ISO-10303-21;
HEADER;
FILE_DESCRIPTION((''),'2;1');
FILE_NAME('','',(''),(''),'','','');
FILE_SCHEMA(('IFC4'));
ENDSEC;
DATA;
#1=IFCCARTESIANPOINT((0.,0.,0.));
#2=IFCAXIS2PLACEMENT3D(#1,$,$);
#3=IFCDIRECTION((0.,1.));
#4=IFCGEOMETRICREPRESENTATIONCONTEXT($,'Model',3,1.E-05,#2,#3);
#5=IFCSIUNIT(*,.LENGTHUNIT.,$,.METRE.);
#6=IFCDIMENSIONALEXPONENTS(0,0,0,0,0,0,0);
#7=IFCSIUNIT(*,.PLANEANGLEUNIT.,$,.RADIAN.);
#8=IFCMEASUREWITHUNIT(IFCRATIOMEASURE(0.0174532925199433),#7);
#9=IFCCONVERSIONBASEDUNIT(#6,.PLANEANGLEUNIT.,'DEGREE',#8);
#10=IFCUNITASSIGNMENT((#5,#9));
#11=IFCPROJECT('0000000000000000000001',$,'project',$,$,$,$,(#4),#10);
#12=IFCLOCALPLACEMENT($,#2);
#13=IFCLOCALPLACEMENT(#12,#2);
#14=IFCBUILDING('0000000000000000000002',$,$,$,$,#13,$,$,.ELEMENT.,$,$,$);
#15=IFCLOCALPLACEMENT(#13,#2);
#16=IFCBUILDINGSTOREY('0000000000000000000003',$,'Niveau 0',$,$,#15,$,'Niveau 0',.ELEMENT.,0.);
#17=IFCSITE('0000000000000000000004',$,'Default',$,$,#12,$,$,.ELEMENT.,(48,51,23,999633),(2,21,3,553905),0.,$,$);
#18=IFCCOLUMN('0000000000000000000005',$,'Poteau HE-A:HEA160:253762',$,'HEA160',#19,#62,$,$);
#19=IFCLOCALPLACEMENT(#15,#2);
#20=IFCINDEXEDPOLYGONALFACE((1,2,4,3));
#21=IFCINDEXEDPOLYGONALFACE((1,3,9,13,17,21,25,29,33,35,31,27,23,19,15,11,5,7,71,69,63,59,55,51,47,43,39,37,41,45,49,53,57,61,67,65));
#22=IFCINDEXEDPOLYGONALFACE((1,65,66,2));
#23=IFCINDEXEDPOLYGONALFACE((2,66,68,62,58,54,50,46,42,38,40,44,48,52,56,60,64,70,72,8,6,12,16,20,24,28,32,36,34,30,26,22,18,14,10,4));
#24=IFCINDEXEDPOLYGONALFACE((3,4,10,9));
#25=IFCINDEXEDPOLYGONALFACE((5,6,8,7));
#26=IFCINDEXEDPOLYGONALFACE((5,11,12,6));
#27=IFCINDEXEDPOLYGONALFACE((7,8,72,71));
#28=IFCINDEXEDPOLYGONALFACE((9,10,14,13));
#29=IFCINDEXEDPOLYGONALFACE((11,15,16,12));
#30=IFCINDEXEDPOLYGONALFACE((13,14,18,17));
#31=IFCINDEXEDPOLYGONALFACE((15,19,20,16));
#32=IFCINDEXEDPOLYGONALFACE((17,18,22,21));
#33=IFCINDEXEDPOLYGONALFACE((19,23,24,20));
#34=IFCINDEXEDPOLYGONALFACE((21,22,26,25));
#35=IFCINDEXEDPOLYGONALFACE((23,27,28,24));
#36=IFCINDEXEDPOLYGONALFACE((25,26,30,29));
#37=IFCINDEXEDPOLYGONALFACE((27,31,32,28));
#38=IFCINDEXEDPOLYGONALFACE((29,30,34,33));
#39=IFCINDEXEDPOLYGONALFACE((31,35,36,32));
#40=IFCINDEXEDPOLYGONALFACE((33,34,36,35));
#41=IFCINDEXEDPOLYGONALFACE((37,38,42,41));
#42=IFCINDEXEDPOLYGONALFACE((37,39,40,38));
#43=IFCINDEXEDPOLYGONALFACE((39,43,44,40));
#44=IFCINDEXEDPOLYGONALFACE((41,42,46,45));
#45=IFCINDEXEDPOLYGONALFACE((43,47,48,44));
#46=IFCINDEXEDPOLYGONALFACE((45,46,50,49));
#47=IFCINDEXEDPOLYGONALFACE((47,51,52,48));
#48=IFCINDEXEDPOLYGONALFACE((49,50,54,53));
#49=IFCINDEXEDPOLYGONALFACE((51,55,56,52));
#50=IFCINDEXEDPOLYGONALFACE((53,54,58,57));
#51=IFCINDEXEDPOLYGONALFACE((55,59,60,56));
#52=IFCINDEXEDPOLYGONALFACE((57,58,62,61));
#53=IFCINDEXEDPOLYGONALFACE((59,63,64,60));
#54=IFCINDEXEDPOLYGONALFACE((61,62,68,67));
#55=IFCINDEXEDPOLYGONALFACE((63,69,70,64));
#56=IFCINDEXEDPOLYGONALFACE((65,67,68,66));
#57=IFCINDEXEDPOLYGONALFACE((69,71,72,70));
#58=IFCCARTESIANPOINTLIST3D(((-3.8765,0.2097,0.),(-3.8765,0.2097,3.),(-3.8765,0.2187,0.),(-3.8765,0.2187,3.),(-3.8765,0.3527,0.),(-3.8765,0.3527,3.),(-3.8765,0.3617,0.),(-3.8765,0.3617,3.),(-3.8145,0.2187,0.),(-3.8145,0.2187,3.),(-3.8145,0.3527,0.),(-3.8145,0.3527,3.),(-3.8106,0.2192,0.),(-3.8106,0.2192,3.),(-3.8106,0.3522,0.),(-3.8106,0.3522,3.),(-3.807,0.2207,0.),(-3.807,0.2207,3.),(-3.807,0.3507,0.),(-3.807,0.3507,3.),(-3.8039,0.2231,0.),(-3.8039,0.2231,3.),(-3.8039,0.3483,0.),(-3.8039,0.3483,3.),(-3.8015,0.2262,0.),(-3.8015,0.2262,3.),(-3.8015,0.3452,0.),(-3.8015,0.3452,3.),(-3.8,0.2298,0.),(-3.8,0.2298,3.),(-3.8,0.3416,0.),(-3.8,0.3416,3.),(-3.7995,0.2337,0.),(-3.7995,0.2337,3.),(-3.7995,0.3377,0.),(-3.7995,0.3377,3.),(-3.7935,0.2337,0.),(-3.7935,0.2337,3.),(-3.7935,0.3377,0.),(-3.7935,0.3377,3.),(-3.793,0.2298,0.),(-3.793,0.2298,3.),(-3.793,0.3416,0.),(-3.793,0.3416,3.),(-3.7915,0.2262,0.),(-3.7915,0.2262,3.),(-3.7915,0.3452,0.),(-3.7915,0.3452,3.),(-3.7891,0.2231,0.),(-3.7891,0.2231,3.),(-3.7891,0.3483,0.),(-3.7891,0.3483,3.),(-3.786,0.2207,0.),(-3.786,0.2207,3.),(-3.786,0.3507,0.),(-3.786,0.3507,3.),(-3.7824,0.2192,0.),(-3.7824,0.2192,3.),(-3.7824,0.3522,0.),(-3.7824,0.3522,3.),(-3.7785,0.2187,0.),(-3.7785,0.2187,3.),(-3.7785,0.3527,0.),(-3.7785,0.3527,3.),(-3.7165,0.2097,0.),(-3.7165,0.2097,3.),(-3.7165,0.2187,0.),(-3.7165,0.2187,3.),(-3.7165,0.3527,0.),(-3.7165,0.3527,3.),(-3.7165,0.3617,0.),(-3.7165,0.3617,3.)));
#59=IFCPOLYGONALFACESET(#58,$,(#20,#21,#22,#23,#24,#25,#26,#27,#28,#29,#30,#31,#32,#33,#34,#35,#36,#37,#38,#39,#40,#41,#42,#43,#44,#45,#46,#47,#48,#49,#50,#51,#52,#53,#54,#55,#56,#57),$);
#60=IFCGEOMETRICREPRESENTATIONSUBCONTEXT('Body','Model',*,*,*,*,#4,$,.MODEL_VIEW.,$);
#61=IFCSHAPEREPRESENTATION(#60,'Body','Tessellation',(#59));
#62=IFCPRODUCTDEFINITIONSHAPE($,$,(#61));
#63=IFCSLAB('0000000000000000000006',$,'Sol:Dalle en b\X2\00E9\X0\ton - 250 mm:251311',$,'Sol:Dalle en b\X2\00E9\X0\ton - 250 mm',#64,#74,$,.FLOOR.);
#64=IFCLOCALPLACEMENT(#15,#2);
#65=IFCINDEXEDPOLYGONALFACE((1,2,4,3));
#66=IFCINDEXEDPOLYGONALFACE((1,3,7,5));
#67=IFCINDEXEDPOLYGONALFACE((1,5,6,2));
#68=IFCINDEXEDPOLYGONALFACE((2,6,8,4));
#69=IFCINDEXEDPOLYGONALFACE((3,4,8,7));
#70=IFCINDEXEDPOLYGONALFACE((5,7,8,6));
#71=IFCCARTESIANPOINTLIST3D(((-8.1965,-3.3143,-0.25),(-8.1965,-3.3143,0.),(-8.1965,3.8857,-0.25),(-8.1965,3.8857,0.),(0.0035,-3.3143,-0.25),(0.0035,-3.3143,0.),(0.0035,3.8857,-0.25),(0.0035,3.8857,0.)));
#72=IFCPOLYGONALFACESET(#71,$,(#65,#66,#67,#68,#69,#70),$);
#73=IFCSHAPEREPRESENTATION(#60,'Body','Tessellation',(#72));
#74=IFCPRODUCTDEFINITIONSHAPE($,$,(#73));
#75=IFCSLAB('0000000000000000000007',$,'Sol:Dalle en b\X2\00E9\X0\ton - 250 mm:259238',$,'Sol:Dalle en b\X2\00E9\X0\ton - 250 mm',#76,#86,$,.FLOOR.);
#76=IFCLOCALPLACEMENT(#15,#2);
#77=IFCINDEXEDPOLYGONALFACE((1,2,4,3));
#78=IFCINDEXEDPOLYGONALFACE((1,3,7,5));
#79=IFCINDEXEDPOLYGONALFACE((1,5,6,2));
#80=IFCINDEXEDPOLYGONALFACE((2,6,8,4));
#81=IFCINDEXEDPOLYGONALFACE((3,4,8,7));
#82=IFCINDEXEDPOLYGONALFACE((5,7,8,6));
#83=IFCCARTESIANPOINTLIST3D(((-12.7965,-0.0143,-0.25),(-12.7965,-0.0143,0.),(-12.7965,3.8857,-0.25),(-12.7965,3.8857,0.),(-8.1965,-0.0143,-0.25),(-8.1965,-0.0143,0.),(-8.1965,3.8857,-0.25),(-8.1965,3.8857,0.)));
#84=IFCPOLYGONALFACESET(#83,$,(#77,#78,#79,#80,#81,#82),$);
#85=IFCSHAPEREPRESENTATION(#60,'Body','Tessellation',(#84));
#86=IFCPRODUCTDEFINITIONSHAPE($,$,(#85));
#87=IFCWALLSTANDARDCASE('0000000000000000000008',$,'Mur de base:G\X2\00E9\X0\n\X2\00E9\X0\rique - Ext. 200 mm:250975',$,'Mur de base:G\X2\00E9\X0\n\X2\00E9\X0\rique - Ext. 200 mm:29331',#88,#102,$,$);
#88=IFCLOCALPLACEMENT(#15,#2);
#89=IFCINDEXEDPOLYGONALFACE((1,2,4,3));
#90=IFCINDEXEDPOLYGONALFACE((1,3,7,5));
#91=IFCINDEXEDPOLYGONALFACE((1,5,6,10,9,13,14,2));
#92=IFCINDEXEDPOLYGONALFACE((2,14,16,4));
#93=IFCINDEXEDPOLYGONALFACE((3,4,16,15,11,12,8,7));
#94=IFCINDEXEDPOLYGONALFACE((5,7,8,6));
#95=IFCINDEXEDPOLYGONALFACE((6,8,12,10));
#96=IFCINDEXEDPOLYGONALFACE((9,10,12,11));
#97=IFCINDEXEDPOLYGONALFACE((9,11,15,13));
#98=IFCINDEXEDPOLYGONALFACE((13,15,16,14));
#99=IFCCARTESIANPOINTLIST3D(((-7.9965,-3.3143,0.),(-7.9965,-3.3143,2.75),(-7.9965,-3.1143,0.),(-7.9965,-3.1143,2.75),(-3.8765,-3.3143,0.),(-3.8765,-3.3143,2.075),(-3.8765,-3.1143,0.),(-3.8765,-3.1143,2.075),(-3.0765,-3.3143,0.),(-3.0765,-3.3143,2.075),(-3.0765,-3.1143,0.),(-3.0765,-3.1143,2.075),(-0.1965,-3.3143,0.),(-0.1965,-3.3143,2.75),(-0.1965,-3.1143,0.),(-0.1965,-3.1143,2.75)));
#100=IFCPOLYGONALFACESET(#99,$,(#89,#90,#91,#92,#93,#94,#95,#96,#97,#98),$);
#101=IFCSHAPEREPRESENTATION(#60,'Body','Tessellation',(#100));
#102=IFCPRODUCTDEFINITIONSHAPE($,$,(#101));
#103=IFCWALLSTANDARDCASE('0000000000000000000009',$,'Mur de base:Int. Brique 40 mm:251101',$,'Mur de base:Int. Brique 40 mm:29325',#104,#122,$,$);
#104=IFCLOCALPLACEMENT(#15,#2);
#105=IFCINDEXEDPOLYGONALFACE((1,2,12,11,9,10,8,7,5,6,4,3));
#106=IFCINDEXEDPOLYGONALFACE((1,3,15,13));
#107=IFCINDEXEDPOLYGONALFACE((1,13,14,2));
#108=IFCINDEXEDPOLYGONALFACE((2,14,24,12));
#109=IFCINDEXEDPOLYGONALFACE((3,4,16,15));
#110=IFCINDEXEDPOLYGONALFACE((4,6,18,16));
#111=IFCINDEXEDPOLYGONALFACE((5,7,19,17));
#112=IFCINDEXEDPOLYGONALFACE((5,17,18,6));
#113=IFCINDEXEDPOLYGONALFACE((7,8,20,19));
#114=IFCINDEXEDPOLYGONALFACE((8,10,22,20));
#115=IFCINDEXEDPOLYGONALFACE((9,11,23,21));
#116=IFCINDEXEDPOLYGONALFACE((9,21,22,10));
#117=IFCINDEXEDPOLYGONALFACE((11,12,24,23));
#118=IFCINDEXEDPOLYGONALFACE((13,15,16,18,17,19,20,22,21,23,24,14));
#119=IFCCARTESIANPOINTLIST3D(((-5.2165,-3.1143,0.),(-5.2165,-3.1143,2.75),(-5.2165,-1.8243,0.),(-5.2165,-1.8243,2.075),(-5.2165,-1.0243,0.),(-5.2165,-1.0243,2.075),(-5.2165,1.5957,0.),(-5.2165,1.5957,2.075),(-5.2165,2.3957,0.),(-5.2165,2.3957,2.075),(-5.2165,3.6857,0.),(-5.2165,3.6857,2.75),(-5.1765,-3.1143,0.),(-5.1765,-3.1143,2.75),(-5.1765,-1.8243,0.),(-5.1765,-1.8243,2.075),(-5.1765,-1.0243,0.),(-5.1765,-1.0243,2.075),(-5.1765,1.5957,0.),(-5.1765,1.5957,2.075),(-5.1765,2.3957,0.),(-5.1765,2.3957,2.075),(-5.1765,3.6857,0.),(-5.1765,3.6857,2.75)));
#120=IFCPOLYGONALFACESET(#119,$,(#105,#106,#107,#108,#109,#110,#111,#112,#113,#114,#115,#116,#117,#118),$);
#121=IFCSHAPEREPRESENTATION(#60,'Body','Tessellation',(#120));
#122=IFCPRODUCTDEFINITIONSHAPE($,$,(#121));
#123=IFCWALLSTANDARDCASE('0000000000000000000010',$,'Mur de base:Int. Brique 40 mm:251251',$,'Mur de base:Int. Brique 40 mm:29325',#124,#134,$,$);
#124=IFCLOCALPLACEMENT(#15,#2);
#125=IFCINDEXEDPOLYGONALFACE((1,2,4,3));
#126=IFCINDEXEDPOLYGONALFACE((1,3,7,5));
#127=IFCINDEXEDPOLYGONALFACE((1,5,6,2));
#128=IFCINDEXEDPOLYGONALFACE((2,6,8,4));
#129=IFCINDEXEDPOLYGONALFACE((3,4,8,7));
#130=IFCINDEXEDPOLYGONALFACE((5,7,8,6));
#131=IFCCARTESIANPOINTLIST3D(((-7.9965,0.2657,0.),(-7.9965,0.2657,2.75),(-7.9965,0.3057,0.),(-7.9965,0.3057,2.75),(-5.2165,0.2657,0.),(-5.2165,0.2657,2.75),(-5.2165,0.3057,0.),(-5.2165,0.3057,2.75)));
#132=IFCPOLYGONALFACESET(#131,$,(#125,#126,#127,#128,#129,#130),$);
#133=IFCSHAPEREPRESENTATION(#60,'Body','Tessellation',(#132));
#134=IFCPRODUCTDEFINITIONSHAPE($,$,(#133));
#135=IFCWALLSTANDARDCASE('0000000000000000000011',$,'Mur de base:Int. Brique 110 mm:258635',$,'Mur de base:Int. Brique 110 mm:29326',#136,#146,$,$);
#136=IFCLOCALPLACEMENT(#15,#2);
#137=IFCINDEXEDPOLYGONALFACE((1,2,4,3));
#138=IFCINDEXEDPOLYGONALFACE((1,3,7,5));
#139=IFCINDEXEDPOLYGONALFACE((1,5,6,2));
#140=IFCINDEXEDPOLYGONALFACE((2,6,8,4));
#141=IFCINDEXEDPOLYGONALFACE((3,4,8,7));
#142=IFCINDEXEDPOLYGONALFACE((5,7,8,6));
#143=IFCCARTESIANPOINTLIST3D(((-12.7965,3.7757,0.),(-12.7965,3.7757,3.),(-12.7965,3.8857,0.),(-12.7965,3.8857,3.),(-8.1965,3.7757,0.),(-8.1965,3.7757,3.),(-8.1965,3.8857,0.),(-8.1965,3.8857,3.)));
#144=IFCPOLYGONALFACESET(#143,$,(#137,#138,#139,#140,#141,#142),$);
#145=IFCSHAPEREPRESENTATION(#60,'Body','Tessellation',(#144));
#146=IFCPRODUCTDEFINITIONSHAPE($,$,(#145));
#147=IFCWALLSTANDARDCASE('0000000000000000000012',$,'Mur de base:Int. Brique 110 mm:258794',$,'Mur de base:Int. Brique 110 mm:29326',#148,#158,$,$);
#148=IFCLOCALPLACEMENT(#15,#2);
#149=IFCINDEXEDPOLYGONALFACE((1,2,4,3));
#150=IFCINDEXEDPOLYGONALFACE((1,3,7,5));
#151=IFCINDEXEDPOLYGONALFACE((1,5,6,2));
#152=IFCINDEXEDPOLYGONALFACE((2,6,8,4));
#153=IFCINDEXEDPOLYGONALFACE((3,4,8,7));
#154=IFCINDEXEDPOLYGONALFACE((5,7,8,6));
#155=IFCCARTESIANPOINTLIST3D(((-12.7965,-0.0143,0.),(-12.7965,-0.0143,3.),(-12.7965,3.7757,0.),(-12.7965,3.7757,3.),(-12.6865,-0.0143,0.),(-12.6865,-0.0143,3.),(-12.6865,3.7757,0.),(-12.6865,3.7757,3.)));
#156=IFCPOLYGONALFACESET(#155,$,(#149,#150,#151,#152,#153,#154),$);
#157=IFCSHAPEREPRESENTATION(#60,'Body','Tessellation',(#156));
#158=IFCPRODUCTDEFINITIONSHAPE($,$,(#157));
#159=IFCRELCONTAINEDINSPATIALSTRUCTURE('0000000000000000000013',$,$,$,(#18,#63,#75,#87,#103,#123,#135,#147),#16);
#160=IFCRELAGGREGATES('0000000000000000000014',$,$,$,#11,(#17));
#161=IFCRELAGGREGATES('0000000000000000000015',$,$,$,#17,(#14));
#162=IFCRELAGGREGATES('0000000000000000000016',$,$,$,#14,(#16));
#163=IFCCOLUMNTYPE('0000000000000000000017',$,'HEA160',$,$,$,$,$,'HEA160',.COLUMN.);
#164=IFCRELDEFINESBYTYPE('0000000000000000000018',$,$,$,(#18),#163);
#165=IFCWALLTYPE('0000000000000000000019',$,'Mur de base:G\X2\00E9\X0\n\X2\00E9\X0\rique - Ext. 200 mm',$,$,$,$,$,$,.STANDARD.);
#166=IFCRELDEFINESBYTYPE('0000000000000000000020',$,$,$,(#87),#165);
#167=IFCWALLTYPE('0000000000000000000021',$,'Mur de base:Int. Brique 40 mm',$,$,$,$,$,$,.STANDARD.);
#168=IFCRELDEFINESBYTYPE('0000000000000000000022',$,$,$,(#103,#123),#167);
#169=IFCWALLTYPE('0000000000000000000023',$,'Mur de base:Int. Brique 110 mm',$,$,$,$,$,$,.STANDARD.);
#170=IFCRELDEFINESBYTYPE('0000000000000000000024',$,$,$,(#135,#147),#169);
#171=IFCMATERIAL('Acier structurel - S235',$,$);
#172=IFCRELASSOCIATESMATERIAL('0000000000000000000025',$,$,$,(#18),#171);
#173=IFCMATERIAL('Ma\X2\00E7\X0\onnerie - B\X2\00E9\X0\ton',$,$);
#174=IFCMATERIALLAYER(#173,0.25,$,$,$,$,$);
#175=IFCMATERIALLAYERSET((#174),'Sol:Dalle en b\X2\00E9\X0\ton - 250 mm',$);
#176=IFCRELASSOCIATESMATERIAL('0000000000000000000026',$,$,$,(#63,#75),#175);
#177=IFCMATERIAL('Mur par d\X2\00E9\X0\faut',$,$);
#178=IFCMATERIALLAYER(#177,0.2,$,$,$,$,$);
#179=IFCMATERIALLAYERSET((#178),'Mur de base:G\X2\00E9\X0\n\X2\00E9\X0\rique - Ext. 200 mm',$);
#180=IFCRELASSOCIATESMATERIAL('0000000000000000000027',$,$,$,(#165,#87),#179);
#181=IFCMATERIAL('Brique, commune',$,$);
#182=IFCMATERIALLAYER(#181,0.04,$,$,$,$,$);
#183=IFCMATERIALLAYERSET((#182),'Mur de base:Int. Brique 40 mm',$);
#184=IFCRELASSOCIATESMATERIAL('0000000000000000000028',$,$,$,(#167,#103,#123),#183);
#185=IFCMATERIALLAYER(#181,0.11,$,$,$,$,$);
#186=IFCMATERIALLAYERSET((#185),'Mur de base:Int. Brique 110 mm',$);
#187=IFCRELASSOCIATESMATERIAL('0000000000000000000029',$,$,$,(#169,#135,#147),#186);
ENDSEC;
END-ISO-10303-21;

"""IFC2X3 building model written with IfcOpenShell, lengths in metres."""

from ifc_helpers import new_model, entity, si_unit, converted_unit, direction, frame, frame_2d, origin, origin_2d_with_axis, place, context, subcontext, project, spatial, polyline, rectangle, i_section, extrude, clip, halfspace, bounded_halfspace, source, transform, mapped, material, layer, layer_set, layer_usage, type_object, type_shapes, element, save


model = new_model("IFC2X3")

# Units and contexts
model_context = context("Model", 3, precision=1e-05, world=origin(), true_north=direction((0.0, 1.0)))
body_context = subcontext(model_context, "Body", "Model", "MODEL_VIEW")
ifc_project = project(units=[si_unit("LENGTHUNIT", "METRE"), converted_unit("PLANEANGLEUNIT", "DEGREE", entity("IfcRatioMeasure", 0.0174532925199433), si_unit("PLANEANGLEUNIT", "RADIAN"), dimensions=[0, 0, 0, 0, 0, 0, 0])], contexts=[model_context])

# Site, building, storey
site_placement = place(None, origin())
site = spatial("IfcSite", under=ifc_project, at=site_placement, Name="Default", CompositionType="ELEMENT", RefLatitude=(48, 51, 23, 999633), RefLongitude=(2, 21, 3, 553905), RefElevation=0.0)
building_placement = place(site_placement, origin())
building = spatial("IfcBuilding", under=site, at=building_placement, CompositionType="ELEMENT")
storey_placement = place(building_placement, origin())
storey = spatial("IfcBuildingStorey", under=building, at=storey_placement, Name="Niveau 0", LongName="Niveau 0", CompositionType="ELEMENT", Elevation=0.0)

# Column
ifc_material_1 = material(Name="Acier structurel - S235")
column_type = type_object("IfcColumnType", Name="HEA160", ElementType="HEA160", PredefinedType="COLUMN")
shared_shape = source(origin(), body_context, "Body", "SweptSolid", [
    extrude(i_section(OverallWidth=0.16, OverallDepth=0.152, WebThickness=0.006, FlangeThickness=0.009, FilletRadius=0.015, at=frame_2d((0.0, 0.0), x_axis=(0.0, 1.0))), frame((0.0, 0.0, 0.0), z_axis=(0.0, 0.0, 1.0), x_axis=(0.0, -1.0, 0.0)), (0.0, 0.0, 1.0), 3.0),
])
type_shapes(column_type, [shared_shape])
column_placement = place(storey_placement, frame((-3.7965, 0.2857, 0.0)))
element("IfcColumn", 1, at=column_placement, inside=storey, type_object=column_type, material=ifc_material_1, Name="Poteau HE-A:HEA160:253762", ObjectType="HEA160", context=body_context, shape_type="MappedRepresentation", body=[
    mapped(shared_shape, transform((0.0, 0.0, 0.0), scale=1.0)),
])

# Slabs
ifc_material_2 = material(Name="Maçonnerie - Béton")
ifc_layer_1 = layer(ifc_material_2, 0.25)
ifc_layer_set_1 = layer_set([ifc_layer_1], Name="Sol:Dalle en béton - 250 mm")
ifc_layer_usage_1 = layer_usage(ifc_layer_set_1, "AXIS3", "POSITIVE", 0.0)
slab_1_placement = place(storey_placement, origin())
element("IfcSlab", 2, at=slab_1_placement, inside=storey, material=ifc_layer_usage_1, Name="Sol:Dalle en béton - 250 mm:251311", ObjectType="Sol:Dalle en béton - 250 mm", PredefinedType="FLOOR", context=body_context, shape_type="SweptSolid", body=[
    extrude(rectangle(XDim=7.2, YDim=8.2, at=frame_2d((0.0, 0.0), x_axis=(1.0, 0.0))), frame((-4.0965, 0.2857, 0.0), z_axis=(0.0, 0.0, -1.0), x_axis=(0.0, 1.0, 0.0)), (0.0, 0.0, 1.0), 0.25),
])
ifc_layer_usage_2 = layer_usage(ifc_layer_set_1, "AXIS3", "POSITIVE", 0.0)
slab_2_placement = place(storey_placement, origin())
element("IfcSlab", 3, at=slab_2_placement, inside=storey, material=ifc_layer_usage_2, Name="Sol:Dalle en béton - 250 mm:259238", ObjectType="Sol:Dalle en béton - 250 mm", PredefinedType="FLOOR", context=body_context, shape_type="SweptSolid", body=[
    extrude(rectangle(XDim=3.9, YDim=4.6, at=origin_2d_with_axis()), frame((-10.4965, 1.9357, 0.0), z_axis=(0.0, 0.0, -1.0), x_axis=(0.0, 1.0, 0.0)), (0.0, 0.0, 1.0), 0.25),
])

# Wall, opening
ifc_material_3 = material(Name="Mur par défaut")
ifc_layer_2 = layer(ifc_material_3, 0.2)
ifc_layer_set_2 = layer_set([ifc_layer_2], Name="Mur de base:Générique - Ext. 200 mm")
ifc_layer_usage_3 = layer_usage(ifc_layer_set_2, "AXIS2", "NEGATIVE", 0.1)
wall_type_1 = type_object("IfcWallType", Name="Mur de base:Générique - Ext. 200 mm", PredefinedType="STANDARD", material=ifc_layer_set_2)
wall_1_placement = place(storey_placement, frame((-0.1965, -3.2143, 0.0), z_axis=(0.0, 0.0, 1.0), x_axis=(-1.0, 0.0, 0.0)))
wall_1 = element("IfcWallStandardCase", 4, at=wall_1_placement, inside=storey, type_object=wall_type_1, material=ifc_layer_usage_3, Name="Mur de base:Générique - Ext. 200 mm:250975", ObjectType="Mur de base:Générique - Ext. 200 mm:29331", context=body_context, shape_type="Clipping", body=[
    clip(extrude(rectangle(XDim=7.8, YDim=0.2, at=frame_2d((3.9, 0.0), x_axis=(-1.0, 0.0))), origin(), (0.0, 0.0, 1.0), 2.75), bounded_halfspace(frame((0.0, -0.1, 2.75), z_axis=(0.0, 0.0, -1.0), x_axis=(-1.0, 0.0, 0.0)), True, frame((0.0, -0.1, 2.75)), polyline([(0.0, 0.0), (7.8, 0.0), (7.8, 0.2), (0.0, 0.2), (0.0, 0.0)]))),
])
opening_1_placement = place(wall_1_placement, frame((2.88, -0.1, 0.0)))
element("IfcOpeningElement", 5, at=opening_1_placement, cuts=wall_1, ObjectType="Opening", context=body_context, shape_type="SweptSolid", body=[
    extrude(rectangle(XDim=2.075, YDim=0.8, at=frame_2d((1.0375, 0.4), x_axis=(1.0, 0.0))), frame((0.0, 0.0, 0.0), z_axis=(0.0, 1.0, 0.0), x_axis=(0.0, 0.0, 1.0)), (0.0, 0.0, 1.0), 0.2),
])

# Wall, openings
ifc_material_4 = material(Name="Brique, commune")
ifc_layer_3 = layer(ifc_material_4, 0.04)
ifc_layer_set_3 = layer_set([ifc_layer_3], Name="Mur de base:Int. Brique 40 mm")
ifc_layer_usage_4 = layer_usage(ifc_layer_set_3, "AXIS2", "NEGATIVE", 0.02)
wall_type_2 = type_object("IfcWallType", Name="Mur de base:Int. Brique 40 mm", PredefinedType="STANDARD", material=ifc_layer_set_3)
wall_2_placement = place(storey_placement, frame((-5.1965, 3.6857, 0.0), z_axis=(0.0, 0.0, 1.0), x_axis=(0.0, -1.0, 0.0)))
wall_2 = element("IfcWallStandardCase", 6, at=wall_2_placement, inside=storey, type_object=wall_type_2, material=ifc_layer_usage_4, Name="Mur de base:Int. Brique 40 mm:251101", ObjectType="Mur de base:Int. Brique 40 mm:29325", context=body_context, shape_type="Clipping", body=[
    clip(extrude(rectangle(XDim=6.8, YDim=0.04, at=frame_2d((3.4, 0.0), x_axis=(-1.0, 0.0))), origin(), (0.0, 0.0, 1.0), 2.75), bounded_halfspace(frame((0.0, -0.02, 2.75), z_axis=(0.0, 0.0, -1.0), x_axis=(0.0, 1.0, 0.0)), True, frame((0.0, -0.02, 2.75)), polyline([(0.0, 0.0), (3.38, 0.0), (3.42, 0.0), (6.8, 0.0), (6.8, 0.04), (0.0, 0.04), (0.0, 0.0)]))),
])
opening_2_placement = place(wall_2_placement, frame((5.51, 0.02, 0.0)))
element("IfcOpeningElement", 7, at=opening_2_placement, cuts=wall_2, ObjectType="Opening", context=body_context, shape_type="SweptSolid", body=[
    extrude(rectangle(XDim=2.075, YDim=0.8, at=frame_2d((1.0375, 0.4), x_axis=(1.0, 0.0))), frame((0.0, 0.0, 0.0), z_axis=(0.0, -1.0, 0.0), x_axis=(0.0, 0.0, 1.0)), (0.0, 0.0, 1.0), 0.04),
])
opening_3_placement = place(wall_2_placement, frame((2.09, 0.02, 0.0)))
element("IfcOpeningElement", 8, at=opening_3_placement, cuts=wall_2, ObjectType="Opening", context=body_context, shape_type="SweptSolid", body=[
    extrude(rectangle(XDim=2.075, YDim=0.8, at=frame_2d((1.0375, 0.4), x_axis=(1.0, 0.0))), frame((0.0, 0.0, 0.0), z_axis=(0.0, -1.0, 0.0), x_axis=(0.0, 0.0, 1.0)), (0.0, 0.0, 1.0), 0.04),
])

# Walls
ifc_layer_usage_5 = layer_usage(ifc_layer_set_3, "AXIS2", "NEGATIVE", 0.02)
wall_3_placement = place(storey_placement, frame((-5.2165, 0.2857, 0.0), z_axis=(0.0, 0.0, 1.0), x_axis=(-1.0, 0.0, 0.0)))
element("IfcWallStandardCase", 9, at=wall_3_placement, inside=storey, type_object=wall_type_2, material=ifc_layer_usage_5, Name="Mur de base:Int. Brique 40 mm:251251", ObjectType="Mur de base:Int. Brique 40 mm:29325", context=body_context, shape_type="Clipping", body=[
    clip(extrude(rectangle(XDim=2.78, YDim=0.04, at=frame_2d((1.39, 0.0), x_axis=(-1.0, 0.0))), origin(), (0.0, 0.0, 1.0), 2.75), bounded_halfspace(frame((0.0, -0.02, 2.75), z_axis=(0.0, 0.0, -1.0), x_axis=(-1.0, 0.0, 0.0)), True, frame((0.0, -0.02, 2.75)), polyline([(0.0, 0.0), (2.78, 0.0), (2.78, 0.04), (0.0, 0.04), (0.0, 0.0)]))),
])
ifc_layer_4 = layer(ifc_material_4, 0.11)
ifc_layer_set_4 = layer_set([ifc_layer_4], Name="Mur de base:Int. Brique 110 mm")
ifc_layer_usage_6 = layer_usage(ifc_layer_set_4, "AXIS2", "NEGATIVE", 0.055)
wall_type_3 = type_object("IfcWallType", Name="Mur de base:Int. Brique 110 mm", PredefinedType="STANDARD", material=ifc_layer_set_4)
wall_4_placement = place(storey_placement, frame((-8.1965, 3.8307, 0.0), z_axis=(0.0, 0.0, 1.0), x_axis=(-1.0, 0.0, 0.0)))
element("IfcWallStandardCase", 10, at=wall_4_placement, inside=storey, type_object=wall_type_3, material=ifc_layer_usage_6, Name="Mur de base:Int. Brique 110 mm:258635", ObjectType="Mur de base:Int. Brique 110 mm:29326", context=body_context, shape_type="Clipping", body=[
    clip(clip(extrude(rectangle(XDim=4.6, YDim=0.11, at=frame_2d((2.3, 0.0), x_axis=(-1.0, 0.0))), origin(), (0.0, 0.0, 1.0), 3.0), bounded_halfspace(frame((0.0, -0.055, 3.4024), z_axis=(0.087156, 0.0, 0.996195), x_axis=(0.0, 1.0, 0.0)), False, frame((0.0, -0.055, 3.4024)), polyline([(0.0, 0.0), (4.6, 0.0), (4.6, 0.11), (0.0, 0.11), (0.0, 0.0)]))), halfspace(origin(), True)),
])
ifc_layer_usage_7 = layer_usage(ifc_layer_set_4, "AXIS2", "NEGATIVE", 0.055)
wall_5_placement = place(storey_placement, frame((-12.7415, 3.7757, 0.0), z_axis=(0.0, 0.0, 1.0), x_axis=(0.0, -1.0, 0.0)))
element("IfcWallStandardCase", 11, at=wall_5_placement, inside=storey, type_object=wall_type_3, material=ifc_layer_usage_7, Name="Mur de base:Int. Brique 110 mm:258794", ObjectType="Mur de base:Int. Brique 110 mm:29326", context=body_context, shape_type="SweptSolid", body=[
    extrude(rectangle(XDim=3.79, YDim=0.11, at=frame_2d((1.895, 0.0), x_axis=(-1.0, 0.0))), origin(), (0.0, 0.0, 1.0), 3.0),
])

save(model, "model.ifc")
